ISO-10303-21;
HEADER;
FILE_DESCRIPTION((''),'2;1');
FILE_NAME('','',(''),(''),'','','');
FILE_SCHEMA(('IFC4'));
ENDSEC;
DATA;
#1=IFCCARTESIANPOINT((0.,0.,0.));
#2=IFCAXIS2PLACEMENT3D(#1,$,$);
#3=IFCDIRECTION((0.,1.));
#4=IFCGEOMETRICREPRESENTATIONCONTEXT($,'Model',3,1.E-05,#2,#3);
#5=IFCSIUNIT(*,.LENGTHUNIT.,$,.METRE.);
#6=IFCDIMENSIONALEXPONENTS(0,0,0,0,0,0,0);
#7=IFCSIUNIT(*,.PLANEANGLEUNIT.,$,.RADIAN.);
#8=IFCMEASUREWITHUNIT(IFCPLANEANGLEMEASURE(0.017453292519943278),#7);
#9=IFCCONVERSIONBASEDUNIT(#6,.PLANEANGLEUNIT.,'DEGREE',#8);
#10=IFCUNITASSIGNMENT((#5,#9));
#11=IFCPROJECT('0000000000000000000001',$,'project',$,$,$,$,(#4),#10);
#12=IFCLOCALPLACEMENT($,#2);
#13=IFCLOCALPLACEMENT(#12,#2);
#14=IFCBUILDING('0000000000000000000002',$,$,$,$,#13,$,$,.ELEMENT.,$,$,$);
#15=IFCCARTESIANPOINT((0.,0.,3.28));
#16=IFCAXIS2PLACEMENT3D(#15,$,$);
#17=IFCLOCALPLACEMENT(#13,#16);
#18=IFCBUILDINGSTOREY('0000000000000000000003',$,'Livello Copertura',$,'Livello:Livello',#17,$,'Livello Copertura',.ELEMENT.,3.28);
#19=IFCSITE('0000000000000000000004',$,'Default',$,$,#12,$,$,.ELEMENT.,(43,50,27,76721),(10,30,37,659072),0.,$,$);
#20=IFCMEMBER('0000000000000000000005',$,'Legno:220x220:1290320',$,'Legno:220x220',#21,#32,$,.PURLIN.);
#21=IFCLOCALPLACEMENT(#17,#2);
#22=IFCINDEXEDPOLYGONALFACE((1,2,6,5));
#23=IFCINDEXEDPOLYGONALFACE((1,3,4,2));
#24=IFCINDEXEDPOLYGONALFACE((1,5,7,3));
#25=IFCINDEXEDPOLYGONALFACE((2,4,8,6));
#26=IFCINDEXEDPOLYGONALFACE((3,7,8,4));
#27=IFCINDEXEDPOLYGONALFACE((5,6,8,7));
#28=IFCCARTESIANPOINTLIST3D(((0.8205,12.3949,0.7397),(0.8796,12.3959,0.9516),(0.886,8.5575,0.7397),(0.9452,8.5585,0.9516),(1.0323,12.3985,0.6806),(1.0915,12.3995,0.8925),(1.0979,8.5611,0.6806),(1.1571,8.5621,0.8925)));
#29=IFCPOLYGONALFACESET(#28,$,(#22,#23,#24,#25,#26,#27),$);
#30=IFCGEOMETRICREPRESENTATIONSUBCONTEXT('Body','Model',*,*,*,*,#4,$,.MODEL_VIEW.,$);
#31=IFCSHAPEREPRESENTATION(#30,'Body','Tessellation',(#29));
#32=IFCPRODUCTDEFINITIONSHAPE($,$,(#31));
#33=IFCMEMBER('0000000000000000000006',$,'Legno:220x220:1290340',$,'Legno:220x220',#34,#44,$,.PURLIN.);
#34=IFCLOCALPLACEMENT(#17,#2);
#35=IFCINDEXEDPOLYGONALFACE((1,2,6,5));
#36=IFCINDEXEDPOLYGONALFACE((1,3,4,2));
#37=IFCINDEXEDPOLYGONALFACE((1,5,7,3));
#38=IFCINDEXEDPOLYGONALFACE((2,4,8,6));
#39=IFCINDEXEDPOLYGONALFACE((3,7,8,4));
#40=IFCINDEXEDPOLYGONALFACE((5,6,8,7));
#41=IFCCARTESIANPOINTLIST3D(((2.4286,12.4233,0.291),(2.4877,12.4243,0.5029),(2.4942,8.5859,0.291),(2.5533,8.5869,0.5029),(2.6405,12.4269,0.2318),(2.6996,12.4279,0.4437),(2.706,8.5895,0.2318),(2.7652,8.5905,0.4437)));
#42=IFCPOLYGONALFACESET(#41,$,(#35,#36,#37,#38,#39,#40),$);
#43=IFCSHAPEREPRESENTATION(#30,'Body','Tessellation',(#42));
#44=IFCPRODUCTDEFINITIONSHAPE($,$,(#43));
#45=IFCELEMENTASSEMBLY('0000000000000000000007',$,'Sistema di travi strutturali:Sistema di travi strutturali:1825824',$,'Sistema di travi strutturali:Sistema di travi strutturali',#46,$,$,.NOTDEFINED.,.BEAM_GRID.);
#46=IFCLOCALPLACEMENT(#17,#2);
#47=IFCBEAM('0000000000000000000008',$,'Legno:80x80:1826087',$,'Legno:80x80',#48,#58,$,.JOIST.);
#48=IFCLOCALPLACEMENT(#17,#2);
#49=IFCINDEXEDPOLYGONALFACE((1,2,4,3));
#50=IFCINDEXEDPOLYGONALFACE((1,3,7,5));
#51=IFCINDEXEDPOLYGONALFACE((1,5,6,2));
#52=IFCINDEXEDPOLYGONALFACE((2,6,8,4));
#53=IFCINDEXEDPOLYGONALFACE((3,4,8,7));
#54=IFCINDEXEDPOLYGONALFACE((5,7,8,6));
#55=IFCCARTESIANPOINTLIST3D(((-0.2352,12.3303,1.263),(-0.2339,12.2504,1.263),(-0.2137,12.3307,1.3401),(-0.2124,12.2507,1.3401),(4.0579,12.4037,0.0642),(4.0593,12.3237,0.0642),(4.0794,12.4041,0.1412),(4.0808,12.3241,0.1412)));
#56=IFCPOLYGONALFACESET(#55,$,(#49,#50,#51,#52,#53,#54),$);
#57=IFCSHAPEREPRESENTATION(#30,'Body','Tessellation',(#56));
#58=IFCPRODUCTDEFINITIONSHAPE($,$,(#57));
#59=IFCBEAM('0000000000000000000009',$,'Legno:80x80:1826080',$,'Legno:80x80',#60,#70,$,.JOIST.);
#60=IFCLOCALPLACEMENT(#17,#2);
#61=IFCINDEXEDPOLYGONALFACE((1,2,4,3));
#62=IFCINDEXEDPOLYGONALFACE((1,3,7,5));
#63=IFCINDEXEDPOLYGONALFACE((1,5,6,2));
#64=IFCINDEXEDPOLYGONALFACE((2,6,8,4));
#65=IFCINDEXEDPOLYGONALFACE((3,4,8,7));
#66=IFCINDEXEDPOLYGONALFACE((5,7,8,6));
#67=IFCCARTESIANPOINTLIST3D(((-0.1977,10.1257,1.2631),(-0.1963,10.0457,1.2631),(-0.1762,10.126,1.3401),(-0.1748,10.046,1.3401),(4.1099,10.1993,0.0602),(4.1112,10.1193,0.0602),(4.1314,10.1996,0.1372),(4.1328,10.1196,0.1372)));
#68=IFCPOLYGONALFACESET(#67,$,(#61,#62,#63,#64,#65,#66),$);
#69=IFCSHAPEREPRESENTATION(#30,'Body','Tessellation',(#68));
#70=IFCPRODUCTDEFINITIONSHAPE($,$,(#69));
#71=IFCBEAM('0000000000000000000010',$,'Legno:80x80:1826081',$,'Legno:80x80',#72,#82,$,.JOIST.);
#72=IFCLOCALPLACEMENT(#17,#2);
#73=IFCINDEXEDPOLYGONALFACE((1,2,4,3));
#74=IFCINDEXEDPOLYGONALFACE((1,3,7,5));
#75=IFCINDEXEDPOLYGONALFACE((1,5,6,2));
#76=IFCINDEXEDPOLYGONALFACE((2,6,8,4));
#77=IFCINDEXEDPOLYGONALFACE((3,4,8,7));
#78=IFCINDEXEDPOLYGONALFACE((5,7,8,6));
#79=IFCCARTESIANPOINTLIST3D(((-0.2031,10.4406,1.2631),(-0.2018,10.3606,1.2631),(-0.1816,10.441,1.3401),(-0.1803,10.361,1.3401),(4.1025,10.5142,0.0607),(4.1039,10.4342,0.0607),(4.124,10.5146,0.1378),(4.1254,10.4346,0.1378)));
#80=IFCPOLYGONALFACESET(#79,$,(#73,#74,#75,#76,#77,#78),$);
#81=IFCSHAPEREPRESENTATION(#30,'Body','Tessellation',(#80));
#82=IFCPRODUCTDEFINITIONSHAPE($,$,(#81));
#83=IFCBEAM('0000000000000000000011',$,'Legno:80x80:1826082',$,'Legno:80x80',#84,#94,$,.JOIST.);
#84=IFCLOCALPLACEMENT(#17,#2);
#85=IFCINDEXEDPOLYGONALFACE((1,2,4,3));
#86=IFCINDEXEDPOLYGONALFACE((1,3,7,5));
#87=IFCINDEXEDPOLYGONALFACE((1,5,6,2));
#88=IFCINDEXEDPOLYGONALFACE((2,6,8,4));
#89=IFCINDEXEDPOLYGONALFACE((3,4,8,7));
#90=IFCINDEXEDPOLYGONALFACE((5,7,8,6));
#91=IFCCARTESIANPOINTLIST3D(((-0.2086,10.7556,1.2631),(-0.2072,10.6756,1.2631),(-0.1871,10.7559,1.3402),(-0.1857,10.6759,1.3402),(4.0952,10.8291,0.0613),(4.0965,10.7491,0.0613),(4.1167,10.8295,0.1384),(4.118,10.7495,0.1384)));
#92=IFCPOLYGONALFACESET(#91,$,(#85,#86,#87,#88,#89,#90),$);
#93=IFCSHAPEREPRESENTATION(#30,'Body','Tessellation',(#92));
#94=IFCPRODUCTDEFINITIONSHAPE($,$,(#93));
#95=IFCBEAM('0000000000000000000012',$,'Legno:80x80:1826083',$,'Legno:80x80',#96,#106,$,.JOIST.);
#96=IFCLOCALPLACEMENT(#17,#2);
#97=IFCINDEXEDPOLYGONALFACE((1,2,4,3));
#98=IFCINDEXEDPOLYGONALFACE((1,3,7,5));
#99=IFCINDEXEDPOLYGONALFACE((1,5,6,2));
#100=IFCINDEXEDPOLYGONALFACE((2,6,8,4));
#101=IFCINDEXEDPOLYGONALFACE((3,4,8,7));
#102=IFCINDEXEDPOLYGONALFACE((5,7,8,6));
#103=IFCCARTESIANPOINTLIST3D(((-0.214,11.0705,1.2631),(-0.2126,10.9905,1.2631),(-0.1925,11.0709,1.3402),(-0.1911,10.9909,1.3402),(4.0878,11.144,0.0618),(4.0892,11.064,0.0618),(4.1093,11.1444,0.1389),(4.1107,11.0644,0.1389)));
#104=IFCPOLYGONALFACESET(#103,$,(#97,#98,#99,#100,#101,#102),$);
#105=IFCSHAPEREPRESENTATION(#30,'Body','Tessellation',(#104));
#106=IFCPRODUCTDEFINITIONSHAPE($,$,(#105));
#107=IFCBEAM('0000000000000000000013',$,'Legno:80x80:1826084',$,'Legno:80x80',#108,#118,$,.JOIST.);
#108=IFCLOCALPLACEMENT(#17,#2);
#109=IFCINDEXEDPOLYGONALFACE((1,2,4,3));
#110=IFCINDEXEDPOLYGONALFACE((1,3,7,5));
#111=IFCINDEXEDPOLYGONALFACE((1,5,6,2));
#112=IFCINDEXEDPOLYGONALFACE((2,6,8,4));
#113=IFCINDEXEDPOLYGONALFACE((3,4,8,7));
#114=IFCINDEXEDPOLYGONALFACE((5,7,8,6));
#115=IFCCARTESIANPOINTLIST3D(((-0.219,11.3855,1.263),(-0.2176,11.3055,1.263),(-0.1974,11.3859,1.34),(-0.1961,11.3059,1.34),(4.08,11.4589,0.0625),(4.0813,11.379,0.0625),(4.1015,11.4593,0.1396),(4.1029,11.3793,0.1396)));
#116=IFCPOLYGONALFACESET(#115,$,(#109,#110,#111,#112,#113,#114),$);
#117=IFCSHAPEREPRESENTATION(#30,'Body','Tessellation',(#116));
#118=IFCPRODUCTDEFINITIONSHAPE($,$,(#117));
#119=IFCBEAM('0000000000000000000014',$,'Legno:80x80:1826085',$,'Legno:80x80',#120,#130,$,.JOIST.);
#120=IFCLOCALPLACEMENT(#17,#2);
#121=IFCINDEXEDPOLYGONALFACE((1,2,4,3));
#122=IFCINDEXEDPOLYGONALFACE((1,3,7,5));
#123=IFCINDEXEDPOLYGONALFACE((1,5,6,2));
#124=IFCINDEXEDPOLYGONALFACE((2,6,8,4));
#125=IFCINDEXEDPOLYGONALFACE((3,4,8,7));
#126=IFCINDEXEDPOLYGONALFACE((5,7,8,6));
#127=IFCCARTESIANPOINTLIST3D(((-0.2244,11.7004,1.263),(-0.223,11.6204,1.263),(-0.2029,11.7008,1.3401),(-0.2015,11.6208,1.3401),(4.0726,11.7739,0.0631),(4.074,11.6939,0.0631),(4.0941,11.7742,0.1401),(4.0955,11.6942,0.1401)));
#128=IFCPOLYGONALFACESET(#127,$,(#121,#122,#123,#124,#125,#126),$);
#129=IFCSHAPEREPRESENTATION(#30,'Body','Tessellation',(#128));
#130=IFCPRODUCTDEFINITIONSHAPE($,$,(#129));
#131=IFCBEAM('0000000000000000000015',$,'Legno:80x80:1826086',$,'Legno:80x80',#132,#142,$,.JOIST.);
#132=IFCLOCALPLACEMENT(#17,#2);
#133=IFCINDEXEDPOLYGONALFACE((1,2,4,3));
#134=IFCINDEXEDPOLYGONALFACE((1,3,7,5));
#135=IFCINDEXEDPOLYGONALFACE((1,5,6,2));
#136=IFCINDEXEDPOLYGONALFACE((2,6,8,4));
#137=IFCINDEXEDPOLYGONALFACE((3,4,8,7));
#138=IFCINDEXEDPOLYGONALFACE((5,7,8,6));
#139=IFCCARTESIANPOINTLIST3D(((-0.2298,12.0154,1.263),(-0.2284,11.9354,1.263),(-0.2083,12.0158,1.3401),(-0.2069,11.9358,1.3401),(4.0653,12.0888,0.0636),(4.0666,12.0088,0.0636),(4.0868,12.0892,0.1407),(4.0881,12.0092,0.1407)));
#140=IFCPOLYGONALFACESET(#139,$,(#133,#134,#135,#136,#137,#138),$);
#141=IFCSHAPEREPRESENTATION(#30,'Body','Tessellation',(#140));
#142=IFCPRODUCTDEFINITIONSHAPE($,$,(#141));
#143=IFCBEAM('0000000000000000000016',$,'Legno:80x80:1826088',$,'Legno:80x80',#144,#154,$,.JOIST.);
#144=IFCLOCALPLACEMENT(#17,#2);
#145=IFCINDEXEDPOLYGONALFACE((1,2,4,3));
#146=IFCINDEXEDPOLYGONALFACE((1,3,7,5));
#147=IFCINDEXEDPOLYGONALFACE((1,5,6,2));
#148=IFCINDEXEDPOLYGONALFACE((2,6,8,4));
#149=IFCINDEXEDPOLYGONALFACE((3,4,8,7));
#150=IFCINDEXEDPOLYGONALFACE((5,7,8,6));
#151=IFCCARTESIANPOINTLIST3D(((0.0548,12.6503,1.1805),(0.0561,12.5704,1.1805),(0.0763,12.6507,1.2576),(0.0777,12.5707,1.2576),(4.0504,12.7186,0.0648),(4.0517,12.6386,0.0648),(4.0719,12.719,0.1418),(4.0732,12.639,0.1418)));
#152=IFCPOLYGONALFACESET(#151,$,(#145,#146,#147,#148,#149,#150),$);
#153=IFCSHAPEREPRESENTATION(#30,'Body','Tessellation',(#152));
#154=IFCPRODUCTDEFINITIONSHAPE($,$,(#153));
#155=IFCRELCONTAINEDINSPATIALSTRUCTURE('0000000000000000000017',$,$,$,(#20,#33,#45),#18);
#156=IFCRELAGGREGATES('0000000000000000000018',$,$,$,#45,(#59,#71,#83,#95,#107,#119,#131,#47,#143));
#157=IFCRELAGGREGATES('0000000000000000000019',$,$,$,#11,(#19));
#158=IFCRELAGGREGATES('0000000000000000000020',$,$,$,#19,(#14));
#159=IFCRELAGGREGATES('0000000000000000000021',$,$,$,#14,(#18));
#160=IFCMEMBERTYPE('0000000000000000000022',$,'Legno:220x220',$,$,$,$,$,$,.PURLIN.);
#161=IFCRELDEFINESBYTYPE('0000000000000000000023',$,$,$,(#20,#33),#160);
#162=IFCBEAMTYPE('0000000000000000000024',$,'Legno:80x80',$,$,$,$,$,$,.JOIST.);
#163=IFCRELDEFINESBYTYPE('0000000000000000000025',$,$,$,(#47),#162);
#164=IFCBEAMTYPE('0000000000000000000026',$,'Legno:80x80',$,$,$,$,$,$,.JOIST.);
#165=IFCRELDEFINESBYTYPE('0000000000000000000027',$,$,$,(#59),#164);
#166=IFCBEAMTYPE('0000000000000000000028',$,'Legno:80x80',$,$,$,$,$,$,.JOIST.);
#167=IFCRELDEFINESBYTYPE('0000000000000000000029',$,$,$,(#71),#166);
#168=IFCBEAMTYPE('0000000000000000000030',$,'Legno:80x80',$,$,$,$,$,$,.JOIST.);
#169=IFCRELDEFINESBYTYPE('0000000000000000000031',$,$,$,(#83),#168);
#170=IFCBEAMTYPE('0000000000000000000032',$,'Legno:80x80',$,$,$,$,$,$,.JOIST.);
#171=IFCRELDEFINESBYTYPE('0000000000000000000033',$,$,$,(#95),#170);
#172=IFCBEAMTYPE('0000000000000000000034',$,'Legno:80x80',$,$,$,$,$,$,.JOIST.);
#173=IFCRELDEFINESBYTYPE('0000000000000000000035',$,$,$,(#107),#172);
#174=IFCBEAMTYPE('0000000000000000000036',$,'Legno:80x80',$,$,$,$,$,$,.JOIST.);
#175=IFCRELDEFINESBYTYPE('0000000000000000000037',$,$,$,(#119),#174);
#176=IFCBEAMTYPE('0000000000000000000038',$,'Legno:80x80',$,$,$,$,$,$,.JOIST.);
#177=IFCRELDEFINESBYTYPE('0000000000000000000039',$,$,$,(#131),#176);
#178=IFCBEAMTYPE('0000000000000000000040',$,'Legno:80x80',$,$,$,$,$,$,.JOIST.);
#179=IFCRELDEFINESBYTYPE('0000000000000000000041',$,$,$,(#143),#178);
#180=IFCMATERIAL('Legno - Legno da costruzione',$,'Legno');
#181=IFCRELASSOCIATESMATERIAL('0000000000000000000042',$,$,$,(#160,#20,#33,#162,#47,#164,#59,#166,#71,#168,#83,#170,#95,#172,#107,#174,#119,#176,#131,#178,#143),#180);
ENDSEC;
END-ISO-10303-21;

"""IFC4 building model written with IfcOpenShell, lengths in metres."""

from ifc_helpers import new_model, entity, si_unit, converted_unit, direction, frame, origin, place, context, subcontext, project, spatial, indexed_curve, outline, extrude, source, transform, mapped, material, type_object, type_shapes, element, aggregate, save


model = new_model("IFC4")

# Units and contexts
model_context = context("Model", 3, precision=1e-05, world=origin(), true_north=direction((0.0, 1.0)))
body_context = subcontext(model_context, "Body", "Model", "MODEL_VIEW")
ifc_project = project(units=[si_unit("LENGTHUNIT", "METRE"), converted_unit("PLANEANGLEUNIT", "DEGREE", entity("IfcPlaneAngleMeasure", 0.017453292519943278), si_unit("PLANEANGLEUNIT", "RADIAN"), dimensions=[0, 0, 0, 0, 0, 0, 0])], contexts=[model_context])

# Site, building, storey
site_placement = place(None, origin())
site = spatial("IfcSite", under=ifc_project, at=site_placement, Name="Default", CompositionType="ELEMENT", RefLatitude=(43, 50, 27, 76721), RefLongitude=(10, 30, 37, 659072), RefElevation=0.0)
building_placement = place(site_placement, origin())
building = spatial("IfcBuilding", under=site, at=building_placement, CompositionType="ELEMENT")
storey_placement = place(building_placement, frame((0.0, 0.0, 3.28)))
storey = spatial("IfcBuildingStorey", under=building, at=storey_placement, Name="Livello Copertura", ObjectType="Livello:Livello", LongName="Livello Copertura", CompositionType="ELEMENT", Elevation=3.28)

# Members
ifc_material = material(Name="Legno - Legno da costruzione", Category="Legno")
member_type = type_object("IfcMemberType", Name="Legno:220x220", PredefinedType="PURLIN", material=ifc_material)
shared_shape_1 = source(origin(), body_context, "Body", "SweptSolid", [
    extrude(outline(indexed_curve([(-1.919, -0.11), (1.919, -0.11), (1.919, 0.11), (-1.919, 0.11), (-1.919, -0.11)], self_intersect=False)), frame((0.0, 0.0, -0.11), z_axis=(0.0, 0.0, 1.0), x_axis=(-1.0, 0.0, 0.0)), (0.0, 0.0, 1.0), 0.22),
])
type_shapes(member_type, [shared_shape_1])
for number, where, z_axis, x_axis, name in (
    (1, (0.9888, 10.4785, 0.8161), (0.268881, 0.004594, 0.963163), (0.017085, -0.999854, 0.0), "Legno:220x220:1290320"),
    (2, (2.5969, 10.5069, 0.3673), (0.268881, 0.004594, 0.963163), (0.017085, -0.999854, 0.0), "Legno:220x220:1290340"),
):
    element("IfcMember", number, at=place(storey_placement, frame(where, z_axis=z_axis, x_axis=x_axis)), inside=storey, type_object=member_type, material=ifc_material, Name=name, ObjectType="Legno:220x220", PredefinedType="PURLIN", context=body_context, shape_type="MappedRepresentation", body=[
        mapped(shared_shape_1, transform((0.0, 0.0, 0.0), scale=1.0)),
    ])

# Element assembly, beams
assembly_1_placement = place(storey_placement, origin())
assembly_1 = element("IfcElementAssembly", 3, at=assembly_1_placement, inside=storey, Name="Sistema di travi strutturali:Sistema di travi strutturali:1825824", ObjectType="Sistema di travi strutturali:Sistema di travi strutturali", AssemblyPlace="NOTDEFINED", PredefinedType="BEAM_GRID")
beam_type_1 = type_object("IfcBeamType", Name="Legno:80x80", PredefinedType="JOIST", material=ifc_material)
shared_shape_2 = source(origin(), body_context, "Body", "SweptSolid", [
    extrude(outline(indexed_curve([(-2.229, -0.04), (2.229, -0.04), (2.229, 0.04), (-2.229, 0.04), (-2.229, -0.04)], self_intersect=False)), frame((0.0, 0.0, -0.04), z_axis=(0.0, 0.0, 1.0), x_axis=(-1.0, 0.0, 0.0)), (0.0, 0.0, 1.0), 0.08),
])
type_shapes(beam_type_1, [shared_shape_2])
beam_1_placement = place(assembly_1_placement, frame((1.9228, 12.3272, 0.7021), z_axis=(0.268881, 0.004594, 0.963163), x_axis=(-0.963022, -0.016456, 0.26892)))
beam_1 = element("IfcBeam", 4, at=beam_1_placement, type_object=beam_type_1, material=ifc_material, Name="Legno:80x80:1826087", ObjectType="Legno:80x80", PredefinedType="JOIST", context=body_context, shape_type="MappedRepresentation", body=[
    mapped(shared_shape_2, transform((0.0, 0.0, 0.0), scale=1.0)),
])
beam_type_2 = type_object("IfcBeamType", Name="Legno:80x80", PredefinedType="JOIST", material=ifc_material)
shared_shape_3 = source(origin(), body_context, "Body", "SweptSolid", [
    extrude(outline(indexed_curve([(-2.2365, -0.04), (2.2365, -0.04), (2.2365, 0.04), (-2.2365, 0.04), (-2.2365, -0.04)], self_intersect=False)), frame((0.0, 0.0, -0.04), z_axis=(0.0, 0.0, 1.0), x_axis=(-1.0, 0.0, 0.0)), (0.0, 0.0, 1.0), 0.08),
])
type_shapes(beam_type_2, [shared_shape_3])
beam_2_placement = place(assembly_1_placement, frame((1.9675, 10.1227, 0.7002), z_axis=(0.268881, 0.004594, 0.963163), x_axis=(-0.963022, -0.016456, 0.26892)))
beam_2 = element("IfcBeam", 5, at=beam_2_placement, type_object=beam_type_2, material=ifc_material, Name="Legno:80x80:1826080", ObjectType="Legno:80x80", PredefinedType="JOIST", context=body_context, shape_type="MappedRepresentation", body=[
    mapped(shared_shape_3, transform((0.0, 0.0, 0.0), scale=1.0)),
])
beam_type_3 = type_object("IfcBeamType", Name="Legno:80x80", PredefinedType="JOIST", material=ifc_material)
shared_shape_4 = source(origin(), body_context, "Body", "SweptSolid", [
    extrude(outline(indexed_curve([(-2.2355, -0.04), (2.2355, -0.04), (2.2355, 0.04), (-2.2355, 0.04), (-2.2355, -0.04)], self_intersect=False)), frame((0.0, 0.0, -0.04), z_axis=(0.0, 0.0, 1.0), x_axis=(-1.0, 0.0, 0.0)), (0.0, 0.0, 1.0), 0.08),
])
type_shapes(beam_type_3, [shared_shape_4])
beam_3_placement = place(assembly_1_placement, frame((1.9611, 10.4376, 0.7004), z_axis=(0.268881, 0.004594, 0.963163), x_axis=(-0.963022, -0.016456, 0.26892)))
beam_3 = element("IfcBeam", 6, at=beam_3_placement, type_object=beam_type_3, material=ifc_material, Name="Legno:80x80:1826081", ObjectType="Legno:80x80", PredefinedType="JOIST", context=body_context, shape_type="MappedRepresentation", body=[
    mapped(shared_shape_4, transform((0.0, 0.0, 0.0), scale=1.0)),
])
beam_type_4 = type_object("IfcBeamType", Name="Legno:80x80", PredefinedType="JOIST", material=ifc_material)
shared_shape_5 = source(origin(), body_context, "Body", "SweptSolid", [
    extrude(outline(indexed_curve([(-2.2345, -0.04), (2.2345, -0.04), (2.2345, 0.04), (-2.2345, 0.04), (-2.2345, -0.04)], self_intersect=False)), frame((0.0, 0.0, -0.04), z_axis=(0.0, 0.0, 1.0), x_axis=(-1.0, 0.0, 0.0)), (0.0, 0.0, 1.0), 0.08),
])
type_shapes(beam_type_4, [shared_shape_5])
beam_4_placement = place(assembly_1_placement, frame((1.9547, 10.7525, 0.7007), z_axis=(0.268881, 0.004594, 0.963163), x_axis=(-0.963022, -0.016456, 0.26892)))
beam_4 = element("IfcBeam", 7, at=beam_4_placement, type_object=beam_type_4, material=ifc_material, Name="Legno:80x80:1826082", ObjectType="Legno:80x80", PredefinedType="JOIST", context=body_context, shape_type="MappedRepresentation", body=[
    mapped(shared_shape_5, transform((0.0, 0.0, 0.0), scale=1.0)),
])
beam_type_5 = type_object("IfcBeamType", Name="Legno:80x80", PredefinedType="JOIST", material=ifc_material)
shared_shape_6 = source(origin(), body_context, "Body", "SweptSolid", [
    extrude(outline(indexed_curve([(-2.2335, -0.04), (2.2335, -0.04), (2.2335, 0.04), (-2.2335, 0.04), (-2.2335, -0.04)], self_intersect=False)), frame((0.0, 0.0, -0.04), z_axis=(0.0, 0.0, 1.0), x_axis=(-1.0, 0.0, 0.0)), (0.0, 0.0, 1.0), 0.08),
])
type_shapes(beam_type_5, [shared_shape_6])
beam_5_placement = place(assembly_1_placement, frame((1.9483, 11.0675, 0.701), z_axis=(0.268881, 0.004594, 0.963163), x_axis=(-0.963022, -0.016456, 0.26892)))
beam_5 = element("IfcBeam", 8, at=beam_5_placement, type_object=beam_type_5, material=ifc_material, Name="Legno:80x80:1826083", ObjectType="Legno:80x80", PredefinedType="JOIST", context=body_context, shape_type="MappedRepresentation", body=[
    mapped(shared_shape_6, transform((0.0, 0.0, 0.0), scale=1.0)),
])
beam_type_6 = type_object("IfcBeamType", Name="Legno:80x80", PredefinedType="JOIST", material=ifc_material)
shared_shape_7 = source(origin(), body_context, "Body", "SweptSolid", [
    extrude(outline(indexed_curve([(-2.232, -0.04), (2.232, -0.04), (2.232, 0.04), (-2.232, 0.04), (-2.232, -0.04)], self_intersect=False)), frame((0.0, 0.0, -0.04), z_axis=(0.0, 0.0, 1.0), x_axis=(-1.0, 0.0, 0.0)), (0.0, 0.0, 1.0), 0.08),
])
type_shapes(beam_type_6, [shared_shape_7])
beam_6_placement = place(assembly_1_placement, frame((1.9419, 11.3824, 0.7013), z_axis=(0.268881, 0.004594, 0.963163), x_axis=(-0.963022, -0.016456, 0.26892)))
beam_6 = element("IfcBeam", 9, at=beam_6_placement, type_object=beam_type_6, material=ifc_material, Name="Legno:80x80:1826084", ObjectType="Legno:80x80", PredefinedType="JOIST", context=body_context, shape_type="MappedRepresentation", body=[
    mapped(shared_shape_7, transform((0.0, 0.0, 0.0), scale=1.0)),
])
beam_type_7 = type_object("IfcBeamType", Name="Legno:80x80", PredefinedType="JOIST", material=ifc_material)
shared_shape_8 = source(origin(), body_context, "Body", "SweptSolid", [
    extrude(outline(indexed_curve([(-2.231, -0.04), (2.231, -0.04), (2.231, 0.04), (-2.231, 0.04), (-2.231, -0.04)], self_intersect=False)), frame((0.0, 0.0, -0.04), z_axis=(0.0, 0.0, 1.0), x_axis=(-1.0, 0.0, 0.0)), (0.0, 0.0, 1.0), 0.08),
])
type_shapes(beam_type_7, [shared_shape_8])
beam_7_placement = place(assembly_1_placement, frame((1.9356, 11.6973, 0.7016), z_axis=(0.268881, 0.004594, 0.963163), x_axis=(-0.963022, -0.016456, 0.26892)))
beam_7 = element("IfcBeam", 10, at=beam_7_placement, type_object=beam_type_7, material=ifc_material, Name="Legno:80x80:1826085", ObjectType="Legno:80x80", PredefinedType="JOIST", context=body_context, shape_type="MappedRepresentation", body=[
    mapped(shared_shape_8, transform((0.0, 0.0, 0.0), scale=1.0)),
])
beam_type_8 = type_object("IfcBeamType", Name="Legno:80x80", PredefinedType="JOIST", material=ifc_material)
shared_shape_9 = source(origin(), body_context, "Body", "SweptSolid", [
    extrude(outline(indexed_curve([(-2.23, -0.04), (2.23, -0.04), (2.23, 0.04), (-2.23, 0.04), (-2.23, -0.04)], self_intersect=False)), frame((0.0, 0.0, -0.04), z_axis=(0.0, 0.0, 1.0), x_axis=(-1.0, 0.0, 0.0)), (0.0, 0.0, 1.0), 0.08),
])
type_shapes(beam_type_8, [shared_shape_9])
beam_8_placement = place(assembly_1_placement, frame((1.9292, 12.0123, 0.7019), z_axis=(0.268881, 0.004594, 0.963163), x_axis=(-0.963022, -0.016456, 0.26892)))
beam_8 = element("IfcBeam", 11, at=beam_8_placement, type_object=beam_type_8, material=ifc_material, Name="Legno:80x80:1826086", ObjectType="Legno:80x80", PredefinedType="JOIST", context=body_context, shape_type="MappedRepresentation", body=[
    mapped(shared_shape_9, transform((0.0, 0.0, 0.0), scale=1.0)),
])
beam_type_9 = type_object("IfcBeamType", Name="Legno:80x80", PredefinedType="JOIST", material=ifc_material)
shared_shape_10 = source(origin(), body_context, "Body", "SweptSolid", [
    extrude(outline(indexed_curve([(-2.0745, -0.04), (2.0745, -0.04), (2.0745, 0.04), (-2.0745, 0.04), (-2.0745, -0.04)], self_intersect=False)), frame((0.0, 0.0, -0.04), z_axis=(0.0, 0.0, 1.0), x_axis=(-1.0, 0.0, 0.0)), (0.0, 0.0, 1.0), 0.08),
])
type_shapes(beam_type_9, [shared_shape_10])
beam_9_placement = place(assembly_1_placement, frame((2.064, 12.6447, 0.6612), z_axis=(0.268881, 0.004594, 0.963163), x_axis=(-0.963022, -0.016456, 0.26892)))
beam_9 = element("IfcBeam", 12, at=beam_9_placement, type_object=beam_type_9, material=ifc_material, Name="Legno:80x80:1826088", ObjectType="Legno:80x80", PredefinedType="JOIST", context=body_context, shape_type="MappedRepresentation", body=[
    mapped(shared_shape_10, transform((0.0, 0.0, 0.0), scale=1.0)),
])
aggregate(assembly_1, [beam_2, beam_3, beam_4, beam_5, beam_6, beam_7, beam_8, beam_1, beam_9])

save(model, "model.ifc")
